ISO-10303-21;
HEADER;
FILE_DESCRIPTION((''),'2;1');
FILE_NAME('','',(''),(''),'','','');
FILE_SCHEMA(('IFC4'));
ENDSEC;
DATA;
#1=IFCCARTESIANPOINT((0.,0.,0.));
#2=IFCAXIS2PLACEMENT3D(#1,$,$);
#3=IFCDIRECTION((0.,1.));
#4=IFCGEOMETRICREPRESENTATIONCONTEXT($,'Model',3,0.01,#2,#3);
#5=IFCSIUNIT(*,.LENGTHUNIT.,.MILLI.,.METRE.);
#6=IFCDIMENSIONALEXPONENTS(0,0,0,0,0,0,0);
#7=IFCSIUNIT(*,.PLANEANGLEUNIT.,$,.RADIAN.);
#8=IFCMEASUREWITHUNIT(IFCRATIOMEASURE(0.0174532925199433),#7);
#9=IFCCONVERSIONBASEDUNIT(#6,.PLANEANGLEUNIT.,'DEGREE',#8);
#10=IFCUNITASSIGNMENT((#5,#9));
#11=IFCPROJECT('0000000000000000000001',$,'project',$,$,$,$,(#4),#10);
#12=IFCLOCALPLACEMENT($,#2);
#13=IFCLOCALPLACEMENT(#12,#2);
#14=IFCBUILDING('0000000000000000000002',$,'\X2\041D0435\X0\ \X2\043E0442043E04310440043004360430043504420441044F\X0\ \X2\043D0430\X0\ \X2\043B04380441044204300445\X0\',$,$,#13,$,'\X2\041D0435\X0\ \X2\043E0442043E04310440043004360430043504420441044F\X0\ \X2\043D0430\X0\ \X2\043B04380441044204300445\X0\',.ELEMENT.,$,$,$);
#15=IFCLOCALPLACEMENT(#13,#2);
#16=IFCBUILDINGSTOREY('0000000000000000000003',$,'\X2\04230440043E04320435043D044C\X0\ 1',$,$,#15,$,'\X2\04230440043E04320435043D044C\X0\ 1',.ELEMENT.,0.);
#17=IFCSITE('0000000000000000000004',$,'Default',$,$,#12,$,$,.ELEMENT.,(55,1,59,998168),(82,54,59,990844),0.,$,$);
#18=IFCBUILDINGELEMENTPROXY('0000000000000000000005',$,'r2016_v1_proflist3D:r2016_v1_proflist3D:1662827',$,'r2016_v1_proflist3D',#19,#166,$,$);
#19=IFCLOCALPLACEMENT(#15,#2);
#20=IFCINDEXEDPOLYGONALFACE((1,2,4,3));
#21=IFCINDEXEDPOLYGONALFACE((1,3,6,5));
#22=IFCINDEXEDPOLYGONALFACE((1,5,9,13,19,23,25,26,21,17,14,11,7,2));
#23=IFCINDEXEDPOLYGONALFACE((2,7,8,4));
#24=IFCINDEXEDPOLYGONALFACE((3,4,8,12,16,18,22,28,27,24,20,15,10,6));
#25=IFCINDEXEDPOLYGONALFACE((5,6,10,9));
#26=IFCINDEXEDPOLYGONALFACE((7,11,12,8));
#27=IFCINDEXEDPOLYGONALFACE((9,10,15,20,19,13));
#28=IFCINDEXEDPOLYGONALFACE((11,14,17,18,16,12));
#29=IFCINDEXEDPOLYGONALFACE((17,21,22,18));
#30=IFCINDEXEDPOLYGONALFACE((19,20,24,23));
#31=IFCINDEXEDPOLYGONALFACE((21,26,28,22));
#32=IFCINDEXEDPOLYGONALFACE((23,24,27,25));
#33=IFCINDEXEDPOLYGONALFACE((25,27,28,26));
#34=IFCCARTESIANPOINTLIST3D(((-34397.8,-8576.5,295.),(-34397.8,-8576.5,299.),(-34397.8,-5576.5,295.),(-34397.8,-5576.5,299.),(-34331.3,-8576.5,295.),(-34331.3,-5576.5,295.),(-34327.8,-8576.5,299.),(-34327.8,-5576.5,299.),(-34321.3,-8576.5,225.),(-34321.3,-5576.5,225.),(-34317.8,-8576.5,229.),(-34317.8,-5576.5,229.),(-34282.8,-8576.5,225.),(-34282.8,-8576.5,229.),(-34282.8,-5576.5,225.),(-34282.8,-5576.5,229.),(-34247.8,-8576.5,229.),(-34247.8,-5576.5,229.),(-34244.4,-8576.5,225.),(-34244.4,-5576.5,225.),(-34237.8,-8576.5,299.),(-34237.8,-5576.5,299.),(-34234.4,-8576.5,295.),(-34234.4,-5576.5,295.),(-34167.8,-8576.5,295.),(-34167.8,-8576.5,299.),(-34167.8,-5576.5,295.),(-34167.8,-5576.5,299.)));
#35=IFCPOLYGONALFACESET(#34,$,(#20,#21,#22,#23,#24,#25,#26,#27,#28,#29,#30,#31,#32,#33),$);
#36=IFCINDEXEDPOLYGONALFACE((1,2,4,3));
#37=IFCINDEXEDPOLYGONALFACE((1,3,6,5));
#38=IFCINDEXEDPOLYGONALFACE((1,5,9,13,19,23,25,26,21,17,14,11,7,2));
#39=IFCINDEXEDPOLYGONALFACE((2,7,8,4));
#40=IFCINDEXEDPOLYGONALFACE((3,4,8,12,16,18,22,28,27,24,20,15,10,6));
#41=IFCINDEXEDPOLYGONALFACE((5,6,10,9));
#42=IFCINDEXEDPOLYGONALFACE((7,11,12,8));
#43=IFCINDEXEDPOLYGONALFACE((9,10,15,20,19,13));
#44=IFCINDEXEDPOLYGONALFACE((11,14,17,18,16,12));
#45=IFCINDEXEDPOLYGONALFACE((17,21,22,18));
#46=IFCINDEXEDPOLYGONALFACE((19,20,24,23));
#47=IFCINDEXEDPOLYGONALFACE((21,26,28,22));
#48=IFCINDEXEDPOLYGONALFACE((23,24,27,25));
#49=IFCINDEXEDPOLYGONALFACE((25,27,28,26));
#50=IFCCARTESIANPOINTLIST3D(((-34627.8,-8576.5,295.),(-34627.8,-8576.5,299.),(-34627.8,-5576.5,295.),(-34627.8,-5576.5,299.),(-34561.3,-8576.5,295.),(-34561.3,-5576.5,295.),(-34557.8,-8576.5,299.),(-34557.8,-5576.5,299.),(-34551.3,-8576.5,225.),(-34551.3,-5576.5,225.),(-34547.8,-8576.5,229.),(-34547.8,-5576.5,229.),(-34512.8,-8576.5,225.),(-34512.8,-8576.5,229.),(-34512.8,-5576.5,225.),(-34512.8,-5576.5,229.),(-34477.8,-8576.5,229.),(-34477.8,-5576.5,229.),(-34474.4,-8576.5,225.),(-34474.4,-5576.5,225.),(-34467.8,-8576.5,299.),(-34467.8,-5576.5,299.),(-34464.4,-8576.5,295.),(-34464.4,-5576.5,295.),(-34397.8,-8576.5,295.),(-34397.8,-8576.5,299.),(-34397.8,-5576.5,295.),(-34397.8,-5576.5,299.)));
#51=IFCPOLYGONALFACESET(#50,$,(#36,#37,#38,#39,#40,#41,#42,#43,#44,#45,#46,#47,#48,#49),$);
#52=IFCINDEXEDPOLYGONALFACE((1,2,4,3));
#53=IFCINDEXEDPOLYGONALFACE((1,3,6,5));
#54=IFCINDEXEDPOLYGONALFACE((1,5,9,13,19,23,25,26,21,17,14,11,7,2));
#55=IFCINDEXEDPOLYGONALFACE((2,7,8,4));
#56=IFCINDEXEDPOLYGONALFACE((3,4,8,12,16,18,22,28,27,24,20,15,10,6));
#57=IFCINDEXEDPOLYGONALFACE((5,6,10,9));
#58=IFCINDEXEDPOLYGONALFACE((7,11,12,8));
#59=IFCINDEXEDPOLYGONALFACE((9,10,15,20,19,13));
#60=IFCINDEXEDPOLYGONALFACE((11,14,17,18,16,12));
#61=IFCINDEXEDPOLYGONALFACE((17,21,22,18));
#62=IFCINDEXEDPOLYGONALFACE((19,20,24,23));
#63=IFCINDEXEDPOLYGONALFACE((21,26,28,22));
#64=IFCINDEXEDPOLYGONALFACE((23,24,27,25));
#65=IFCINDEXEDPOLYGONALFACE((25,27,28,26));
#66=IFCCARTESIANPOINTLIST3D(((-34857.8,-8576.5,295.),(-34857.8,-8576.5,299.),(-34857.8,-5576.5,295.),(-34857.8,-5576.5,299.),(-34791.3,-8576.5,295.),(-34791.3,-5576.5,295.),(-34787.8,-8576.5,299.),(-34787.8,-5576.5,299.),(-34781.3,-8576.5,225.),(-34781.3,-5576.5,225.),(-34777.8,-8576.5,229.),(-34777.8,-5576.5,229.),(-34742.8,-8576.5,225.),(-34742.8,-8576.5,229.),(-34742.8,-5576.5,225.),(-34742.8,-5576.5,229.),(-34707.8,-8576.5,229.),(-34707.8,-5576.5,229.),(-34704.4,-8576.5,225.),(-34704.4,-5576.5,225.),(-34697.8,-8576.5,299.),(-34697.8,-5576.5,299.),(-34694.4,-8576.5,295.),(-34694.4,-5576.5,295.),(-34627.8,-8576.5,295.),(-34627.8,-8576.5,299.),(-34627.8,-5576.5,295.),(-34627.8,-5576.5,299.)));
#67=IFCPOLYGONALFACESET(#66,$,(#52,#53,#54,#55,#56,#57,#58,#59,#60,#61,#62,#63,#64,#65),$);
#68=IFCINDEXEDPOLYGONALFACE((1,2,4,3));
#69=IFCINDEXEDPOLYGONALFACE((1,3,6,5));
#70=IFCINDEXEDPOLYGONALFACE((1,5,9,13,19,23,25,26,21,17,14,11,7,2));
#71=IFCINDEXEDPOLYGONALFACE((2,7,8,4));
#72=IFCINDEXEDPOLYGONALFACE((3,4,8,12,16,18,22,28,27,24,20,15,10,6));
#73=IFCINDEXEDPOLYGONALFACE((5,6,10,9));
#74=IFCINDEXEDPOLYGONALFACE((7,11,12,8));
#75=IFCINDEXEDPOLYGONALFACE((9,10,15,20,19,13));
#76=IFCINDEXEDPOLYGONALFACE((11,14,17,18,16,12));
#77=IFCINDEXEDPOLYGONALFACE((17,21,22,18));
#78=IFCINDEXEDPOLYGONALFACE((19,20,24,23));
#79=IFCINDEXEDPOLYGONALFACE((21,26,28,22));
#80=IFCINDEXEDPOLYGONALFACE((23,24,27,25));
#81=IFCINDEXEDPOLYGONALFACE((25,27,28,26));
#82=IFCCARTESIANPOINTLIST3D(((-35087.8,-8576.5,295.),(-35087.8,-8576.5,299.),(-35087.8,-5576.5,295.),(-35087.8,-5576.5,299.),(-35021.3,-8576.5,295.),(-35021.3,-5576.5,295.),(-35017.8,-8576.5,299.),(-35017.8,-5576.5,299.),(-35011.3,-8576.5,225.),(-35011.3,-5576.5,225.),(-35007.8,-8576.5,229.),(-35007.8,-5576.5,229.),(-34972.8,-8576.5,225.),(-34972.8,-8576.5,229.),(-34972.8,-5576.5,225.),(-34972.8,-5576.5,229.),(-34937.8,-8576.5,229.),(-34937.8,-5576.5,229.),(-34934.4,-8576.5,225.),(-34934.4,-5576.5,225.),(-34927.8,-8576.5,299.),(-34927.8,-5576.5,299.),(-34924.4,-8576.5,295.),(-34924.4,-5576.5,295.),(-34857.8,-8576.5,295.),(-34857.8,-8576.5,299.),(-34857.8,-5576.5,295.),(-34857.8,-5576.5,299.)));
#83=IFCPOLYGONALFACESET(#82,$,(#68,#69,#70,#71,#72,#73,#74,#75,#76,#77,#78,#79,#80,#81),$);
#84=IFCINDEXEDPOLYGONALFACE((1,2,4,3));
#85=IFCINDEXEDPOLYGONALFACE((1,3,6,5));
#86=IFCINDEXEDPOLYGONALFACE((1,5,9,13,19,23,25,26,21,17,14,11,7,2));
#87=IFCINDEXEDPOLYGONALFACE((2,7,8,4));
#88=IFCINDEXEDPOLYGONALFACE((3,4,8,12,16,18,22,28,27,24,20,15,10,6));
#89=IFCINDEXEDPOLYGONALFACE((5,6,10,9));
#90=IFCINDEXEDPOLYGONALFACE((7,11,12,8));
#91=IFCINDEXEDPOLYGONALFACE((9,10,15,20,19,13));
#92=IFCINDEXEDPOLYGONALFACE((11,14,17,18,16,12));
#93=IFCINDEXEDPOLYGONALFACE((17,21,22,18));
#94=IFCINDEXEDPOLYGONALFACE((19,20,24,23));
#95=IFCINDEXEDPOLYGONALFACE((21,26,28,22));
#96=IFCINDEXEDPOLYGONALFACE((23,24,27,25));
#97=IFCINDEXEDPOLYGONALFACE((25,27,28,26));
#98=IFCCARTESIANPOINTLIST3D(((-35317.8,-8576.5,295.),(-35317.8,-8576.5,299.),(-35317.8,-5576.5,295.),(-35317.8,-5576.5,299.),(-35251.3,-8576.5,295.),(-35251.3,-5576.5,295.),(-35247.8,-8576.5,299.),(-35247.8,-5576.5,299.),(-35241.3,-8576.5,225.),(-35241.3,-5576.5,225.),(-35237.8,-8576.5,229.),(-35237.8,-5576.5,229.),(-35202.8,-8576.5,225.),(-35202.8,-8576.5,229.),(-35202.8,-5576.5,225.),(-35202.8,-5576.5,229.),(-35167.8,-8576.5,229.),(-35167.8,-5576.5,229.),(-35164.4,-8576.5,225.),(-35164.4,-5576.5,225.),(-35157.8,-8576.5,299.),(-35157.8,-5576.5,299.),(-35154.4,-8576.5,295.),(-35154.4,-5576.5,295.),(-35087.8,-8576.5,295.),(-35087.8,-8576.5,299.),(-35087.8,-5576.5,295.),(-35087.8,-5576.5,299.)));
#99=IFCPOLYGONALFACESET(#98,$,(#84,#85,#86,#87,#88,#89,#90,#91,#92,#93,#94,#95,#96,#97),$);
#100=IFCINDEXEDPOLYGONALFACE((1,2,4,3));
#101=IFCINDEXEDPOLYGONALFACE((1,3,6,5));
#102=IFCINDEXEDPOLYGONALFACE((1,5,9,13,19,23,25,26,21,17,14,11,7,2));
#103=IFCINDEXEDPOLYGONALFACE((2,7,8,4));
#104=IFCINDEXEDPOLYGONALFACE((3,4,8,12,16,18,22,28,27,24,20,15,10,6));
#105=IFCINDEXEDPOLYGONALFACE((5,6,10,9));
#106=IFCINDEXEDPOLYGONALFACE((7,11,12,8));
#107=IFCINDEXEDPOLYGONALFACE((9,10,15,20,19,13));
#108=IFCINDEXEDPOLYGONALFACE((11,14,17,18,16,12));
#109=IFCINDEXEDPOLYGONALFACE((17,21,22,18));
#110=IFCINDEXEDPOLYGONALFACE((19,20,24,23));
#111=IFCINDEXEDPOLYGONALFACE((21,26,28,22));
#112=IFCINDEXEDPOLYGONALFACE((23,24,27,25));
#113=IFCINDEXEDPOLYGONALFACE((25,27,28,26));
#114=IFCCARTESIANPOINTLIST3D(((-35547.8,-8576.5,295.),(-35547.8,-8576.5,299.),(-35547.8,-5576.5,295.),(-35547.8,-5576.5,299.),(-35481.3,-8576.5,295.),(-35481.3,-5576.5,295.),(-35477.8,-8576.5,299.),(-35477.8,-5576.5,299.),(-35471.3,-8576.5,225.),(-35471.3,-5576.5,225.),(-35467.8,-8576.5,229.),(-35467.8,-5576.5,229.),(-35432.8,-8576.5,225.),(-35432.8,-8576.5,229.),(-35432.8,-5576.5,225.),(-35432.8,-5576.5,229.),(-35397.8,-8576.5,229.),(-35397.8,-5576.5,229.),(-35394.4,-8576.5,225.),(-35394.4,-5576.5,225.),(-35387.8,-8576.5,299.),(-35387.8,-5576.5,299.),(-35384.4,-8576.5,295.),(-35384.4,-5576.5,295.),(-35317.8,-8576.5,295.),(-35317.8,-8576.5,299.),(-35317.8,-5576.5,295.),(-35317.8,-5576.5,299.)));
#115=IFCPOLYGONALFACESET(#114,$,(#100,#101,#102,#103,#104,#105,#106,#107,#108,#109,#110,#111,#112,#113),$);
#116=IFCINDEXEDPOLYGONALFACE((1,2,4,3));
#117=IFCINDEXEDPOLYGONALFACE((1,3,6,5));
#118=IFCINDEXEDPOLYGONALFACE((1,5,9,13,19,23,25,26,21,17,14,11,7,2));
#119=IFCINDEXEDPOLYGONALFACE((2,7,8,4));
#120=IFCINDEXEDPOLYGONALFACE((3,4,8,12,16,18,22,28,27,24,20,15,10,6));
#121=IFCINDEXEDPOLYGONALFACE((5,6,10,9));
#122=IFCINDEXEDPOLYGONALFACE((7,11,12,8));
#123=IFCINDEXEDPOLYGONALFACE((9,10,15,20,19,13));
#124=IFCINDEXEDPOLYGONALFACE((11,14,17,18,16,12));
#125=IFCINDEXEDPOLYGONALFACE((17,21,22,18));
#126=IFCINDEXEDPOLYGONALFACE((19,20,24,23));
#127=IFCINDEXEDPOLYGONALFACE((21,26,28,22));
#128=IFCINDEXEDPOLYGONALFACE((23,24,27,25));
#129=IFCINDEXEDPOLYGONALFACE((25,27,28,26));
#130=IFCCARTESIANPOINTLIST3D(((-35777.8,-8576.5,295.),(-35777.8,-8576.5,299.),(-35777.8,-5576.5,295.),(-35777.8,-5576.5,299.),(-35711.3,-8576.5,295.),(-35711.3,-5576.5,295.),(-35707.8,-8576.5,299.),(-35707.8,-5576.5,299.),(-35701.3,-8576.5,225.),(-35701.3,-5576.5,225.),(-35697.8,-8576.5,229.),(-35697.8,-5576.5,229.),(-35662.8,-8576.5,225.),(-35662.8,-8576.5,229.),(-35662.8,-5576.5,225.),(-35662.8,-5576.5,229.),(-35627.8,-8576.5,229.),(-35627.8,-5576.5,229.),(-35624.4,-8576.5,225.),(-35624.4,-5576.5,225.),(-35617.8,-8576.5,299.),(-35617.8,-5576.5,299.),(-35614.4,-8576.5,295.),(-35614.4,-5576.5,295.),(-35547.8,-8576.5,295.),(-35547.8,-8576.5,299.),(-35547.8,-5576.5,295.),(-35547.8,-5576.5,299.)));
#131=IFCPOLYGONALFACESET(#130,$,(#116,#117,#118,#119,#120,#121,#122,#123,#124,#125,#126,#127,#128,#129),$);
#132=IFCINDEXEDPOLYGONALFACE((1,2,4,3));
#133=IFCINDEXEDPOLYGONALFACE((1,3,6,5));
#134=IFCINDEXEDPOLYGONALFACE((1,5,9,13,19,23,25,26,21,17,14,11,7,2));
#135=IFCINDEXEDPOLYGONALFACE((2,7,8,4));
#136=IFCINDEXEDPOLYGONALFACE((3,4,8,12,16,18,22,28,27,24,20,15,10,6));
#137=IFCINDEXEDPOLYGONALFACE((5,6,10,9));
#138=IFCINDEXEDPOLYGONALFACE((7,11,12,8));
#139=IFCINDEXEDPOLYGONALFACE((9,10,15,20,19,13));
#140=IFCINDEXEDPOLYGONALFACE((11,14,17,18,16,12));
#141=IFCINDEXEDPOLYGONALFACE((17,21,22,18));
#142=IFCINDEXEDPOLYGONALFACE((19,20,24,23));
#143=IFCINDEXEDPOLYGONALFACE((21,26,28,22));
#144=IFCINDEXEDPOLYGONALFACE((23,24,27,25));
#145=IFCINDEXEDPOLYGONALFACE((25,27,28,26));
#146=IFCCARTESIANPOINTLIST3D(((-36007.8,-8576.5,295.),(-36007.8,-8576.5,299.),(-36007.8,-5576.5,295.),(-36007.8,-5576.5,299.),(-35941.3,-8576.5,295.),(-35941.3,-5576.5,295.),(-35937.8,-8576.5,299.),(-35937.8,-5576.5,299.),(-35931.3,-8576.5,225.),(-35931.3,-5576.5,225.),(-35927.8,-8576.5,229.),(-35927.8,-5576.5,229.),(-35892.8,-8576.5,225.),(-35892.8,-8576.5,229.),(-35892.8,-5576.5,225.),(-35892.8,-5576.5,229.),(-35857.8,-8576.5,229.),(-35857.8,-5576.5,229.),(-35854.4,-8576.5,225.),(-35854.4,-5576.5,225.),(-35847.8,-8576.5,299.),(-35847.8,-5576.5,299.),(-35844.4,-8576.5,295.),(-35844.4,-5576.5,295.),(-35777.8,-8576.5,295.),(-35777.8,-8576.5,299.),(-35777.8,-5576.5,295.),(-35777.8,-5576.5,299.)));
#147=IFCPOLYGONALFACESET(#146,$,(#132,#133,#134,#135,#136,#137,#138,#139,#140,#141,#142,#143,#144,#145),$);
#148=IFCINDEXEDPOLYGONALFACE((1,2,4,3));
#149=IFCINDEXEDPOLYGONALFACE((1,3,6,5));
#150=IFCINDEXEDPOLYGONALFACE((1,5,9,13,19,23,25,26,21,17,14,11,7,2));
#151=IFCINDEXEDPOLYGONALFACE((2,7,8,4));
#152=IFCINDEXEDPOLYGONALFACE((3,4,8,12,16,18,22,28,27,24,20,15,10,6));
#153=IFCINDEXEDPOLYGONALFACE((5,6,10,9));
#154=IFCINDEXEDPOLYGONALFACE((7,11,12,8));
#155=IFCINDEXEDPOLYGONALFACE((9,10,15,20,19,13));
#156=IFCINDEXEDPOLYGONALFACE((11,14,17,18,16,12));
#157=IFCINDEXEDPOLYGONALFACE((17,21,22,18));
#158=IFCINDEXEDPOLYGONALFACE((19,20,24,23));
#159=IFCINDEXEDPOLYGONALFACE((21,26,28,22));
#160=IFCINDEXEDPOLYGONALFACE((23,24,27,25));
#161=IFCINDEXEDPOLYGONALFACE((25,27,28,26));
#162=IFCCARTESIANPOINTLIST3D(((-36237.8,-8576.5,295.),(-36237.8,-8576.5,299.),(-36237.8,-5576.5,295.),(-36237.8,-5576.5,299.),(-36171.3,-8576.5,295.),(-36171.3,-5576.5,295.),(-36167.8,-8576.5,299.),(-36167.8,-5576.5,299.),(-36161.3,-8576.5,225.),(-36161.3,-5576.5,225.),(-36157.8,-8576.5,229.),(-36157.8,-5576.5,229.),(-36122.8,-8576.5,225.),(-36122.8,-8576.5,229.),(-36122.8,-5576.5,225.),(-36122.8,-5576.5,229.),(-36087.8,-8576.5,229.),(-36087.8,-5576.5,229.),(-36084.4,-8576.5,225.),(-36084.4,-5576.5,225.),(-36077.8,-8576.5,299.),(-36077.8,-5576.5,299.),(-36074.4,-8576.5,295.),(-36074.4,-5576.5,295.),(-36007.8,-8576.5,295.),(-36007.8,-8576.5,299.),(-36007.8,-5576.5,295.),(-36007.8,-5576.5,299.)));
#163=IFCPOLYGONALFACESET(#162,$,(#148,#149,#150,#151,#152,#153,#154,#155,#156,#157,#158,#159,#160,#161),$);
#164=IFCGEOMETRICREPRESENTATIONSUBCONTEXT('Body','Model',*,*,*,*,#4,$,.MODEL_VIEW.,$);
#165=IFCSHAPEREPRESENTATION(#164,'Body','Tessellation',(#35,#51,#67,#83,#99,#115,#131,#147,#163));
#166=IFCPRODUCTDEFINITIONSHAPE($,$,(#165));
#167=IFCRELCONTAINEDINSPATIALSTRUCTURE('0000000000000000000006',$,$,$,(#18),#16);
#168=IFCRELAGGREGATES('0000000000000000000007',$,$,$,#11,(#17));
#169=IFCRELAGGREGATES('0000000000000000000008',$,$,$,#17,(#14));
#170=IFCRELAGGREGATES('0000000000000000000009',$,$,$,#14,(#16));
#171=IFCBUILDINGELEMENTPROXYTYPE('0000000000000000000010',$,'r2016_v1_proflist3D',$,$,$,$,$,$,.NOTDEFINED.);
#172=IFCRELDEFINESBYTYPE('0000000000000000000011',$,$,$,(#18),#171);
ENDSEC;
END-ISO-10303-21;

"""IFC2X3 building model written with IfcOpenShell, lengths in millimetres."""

from ifc_helpers import new_model, entity, si_unit, converted_unit, direction, frame, origin, place, context, subcontext, project, spatial, polyline, outline, extrude, source, transform, mapped, type_object, type_shapes, element, save


model = new_model("IFC2X3")

# Units and contexts
model_context = context("Model", 3, precision=0.01, world=origin(), true_north=direction((0.0, 1.0)))
body_context = subcontext(model_context, "Body", "Model", "MODEL_VIEW")
ifc_project = project(units=[si_unit("LENGTHUNIT", "METRE", prefix="MILLI"), converted_unit("PLANEANGLEUNIT", "DEGREE", entity("IfcRatioMeasure", 0.0174532925199433), si_unit("PLANEANGLEUNIT", "RADIAN"), dimensions=[0, 0, 0, 0, 0, 0, 0])], contexts=[model_context])

# Site, building, storey
site_placement = place(None, origin())
site = spatial("IfcSite", under=ifc_project, at=site_placement, Name="Default", CompositionType="ELEMENT", RefLatitude=(55, 1, 59, 998168), RefLongitude=(82, 54, 59, 990844), RefElevation=0.0)
building_placement = place(site_placement, origin())
building = spatial("IfcBuilding", under=site, at=building_placement, Name="Не отображается на листах", LongName="Не отображается на листах", CompositionType="ELEMENT")
storey_placement = place(building_placement, frame((0.0, 0.0, 0.0)))
storey = spatial("IfcBuildingStorey", under=building, at=storey_placement, Name="Уровень 1", LongName="Уровень 1", CompositionType="ELEMENT", Elevation=0.0)

# Building element proxy
building_element_proxy_type = type_object("IfcBuildingElementProxyType", Name="r2016_v1_proflist3D", PredefinedType="NOTDEFINED")
shared_shape = source(origin(), body_context, "Body", "SweptSolid", [
    extrude(outline(polyline([(-38.0, -40.0), (-47.9, -109.3), (-44.0, -109.9), (-34.6, -44.0), (36.1, -44.0), (41.6, -5.9), (47.0, 32.1), (-20.9, 51.9), (-11.5, 117.8), (-15.4, 118.4), (-25.3, 49.1), (42.6, 29.3), (37.6, -5.4), (32.7, -40.0), (-38.0, -40.0)])), frame((1955.0, -3000.0, -32.0), z_axis=(0.0, -1.0, 0.0), x_axis=(0.141421, 0.0, -0.989949)), (0.0, 0.0, -1.0), 3000.0),
    extrude(outline(polyline([(-38.0, -40.0), (-47.9, -109.3), (-44.0, -109.9), (-34.6, -44.0), (36.1, -44.0), (41.6, -5.9), (47.0, 32.1), (-20.9, 51.9), (-11.5, 117.8), (-15.4, 118.4), (-25.3, 49.1), (42.6, 29.3), (37.6, -5.4), (32.7, -40.0), (-38.0, -40.0)])), frame((1725.0, -3000.0, -32.0), z_axis=(0.0, -1.0, 0.0), x_axis=(0.141421, 0.0, -0.989949)), (0.0, 0.0, -1.0), 3000.0),
    extrude(outline(polyline([(-38.0, -40.0), (-47.9, -109.3), (-44.0, -109.9), (-34.6, -44.0), (36.1, -44.0), (41.6, -5.9), (47.0, 32.1), (-20.9, 51.9), (-11.5, 117.8), (-15.4, 118.4), (-25.3, 49.1), (42.6, 29.3), (37.6, -5.4), (32.7, -40.0), (-38.0, -40.0)])), frame((1495.0, -3000.0, -32.0), z_axis=(0.0, -1.0, 0.0), x_axis=(0.141421, 0.0, -0.989949)), (0.0, 0.0, -1.0), 3000.0),
    extrude(outline(polyline([(-38.0, -40.0), (-47.9, -109.3), (-44.0, -109.9), (-34.6, -44.0), (36.1, -44.0), (41.6, -5.9), (47.0, 32.1), (-20.9, 51.9), (-11.5, 117.8), (-15.4, 118.4), (-25.3, 49.1), (42.6, 29.3), (37.6, -5.4), (32.7, -40.0), (-38.0, -40.0)])), frame((1265.0, -3000.0, -32.0), z_axis=(0.0, -1.0, 0.0), x_axis=(0.141421, 0.0, -0.989949)), (0.0, 0.0, -1.0), 3000.0),
    extrude(outline(polyline([(-38.0, -40.0), (-47.9, -109.3), (-44.0, -109.9), (-34.6, -44.0), (36.1, -44.0), (41.6, -5.9), (47.0, 32.1), (-20.9, 51.9), (-11.5, 117.8), (-15.4, 118.4), (-25.3, 49.1), (42.6, 29.3), (37.6, -5.4), (32.7, -40.0), (-38.0, -40.0)])), frame((1035.0, -3000.0, -32.0), z_axis=(0.0, -1.0, 0.0), x_axis=(0.141421, 0.0, -0.989949)), (0.0, 0.0, -1.0), 3000.0),
    extrude(outline(polyline([(-38.0, -40.0), (-47.9, -109.3), (-44.0, -109.9), (-34.6, -44.0), (36.1, -44.0), (41.6, -5.9), (47.0, 32.1), (-20.9, 51.9), (-11.5, 117.8), (-15.4, 118.4), (-25.3, 49.1), (42.6, 29.3), (37.6, -5.4), (32.7, -40.0), (-38.0, -40.0)])), frame((805.0, -3000.0, -32.0), z_axis=(0.0, -1.0, 0.0), x_axis=(0.141421, 0.0, -0.989949)), (0.0, 0.0, -1.0), 3000.0),
    extrude(outline(polyline([(-38.0, -40.0), (-47.9, -109.3), (-44.0, -109.9), (-34.6, -44.0), (36.1, -44.0), (41.6, -5.9), (47.0, 32.1), (-20.9, 51.9), (-11.5, 117.8), (-15.4, 118.4), (-25.3, 49.1), (42.6, 29.3), (37.6, -5.4), (32.7, -40.0), (-38.0, -40.0)])), frame((575.0, -3000.0, -32.0), z_axis=(0.0, -1.0, 0.0), x_axis=(0.141421, 0.0, -0.989949)), (0.0, 0.0, -1.0), 3000.0),
    extrude(outline(polyline([(-38.0, -40.0), (-47.9, -109.3), (-44.0, -109.9), (-34.6, -44.0), (36.1, -44.0), (41.6, -5.9), (47.0, 32.1), (-20.9, 51.9), (-11.5, 117.8), (-15.4, 118.4), (-25.3, 49.1), (42.6, 29.3), (37.6, -5.4), (32.7, -40.0), (-38.0, -40.0)])), frame((345.0, -3000.0, -32.0), z_axis=(0.0, -1.0, 0.0), x_axis=(0.141421, 0.0, -0.989949)), (0.0, 0.0, -1.0), 3000.0),
    extrude(outline(polyline([(-38.0, -40.0), (-47.9, -109.3), (-44.0, -109.9), (-34.6, -44.0), (36.1, -44.0), (41.6, -5.9), (47.0, 32.1), (-20.9, 51.9), (-11.5, 117.8), (-15.4, 118.4), (-25.3, 49.1), (42.6, 29.3), (37.6, -5.4), (32.7, -40.0), (-38.0, -40.0)])), frame((115.0, -3000.0, -32.0), z_axis=(0.0, -1.0, 0.0), x_axis=(0.141421, 0.0, -0.989949)), (0.0, 0.0, -1.0), 3000.0),
])
type_shapes(building_element_proxy_type, [shared_shape])
proxy_1_placement = place(storey_placement, frame((-36237.8, -5576.5, 299.0)))
element("IfcBuildingElementProxy", 1, at=proxy_1_placement, inside=storey, type_object=building_element_proxy_type, Name="r2016_v1_proflist3D:r2016_v1_proflist3D:1662827", ObjectType="r2016_v1_proflist3D", context=body_context, shape_type="MappedRepresentation", body=[
    mapped(shared_shape, transform((0.0, 0.0, 0.0), scale=1.0)),
])

save(model, "model.ifc")
